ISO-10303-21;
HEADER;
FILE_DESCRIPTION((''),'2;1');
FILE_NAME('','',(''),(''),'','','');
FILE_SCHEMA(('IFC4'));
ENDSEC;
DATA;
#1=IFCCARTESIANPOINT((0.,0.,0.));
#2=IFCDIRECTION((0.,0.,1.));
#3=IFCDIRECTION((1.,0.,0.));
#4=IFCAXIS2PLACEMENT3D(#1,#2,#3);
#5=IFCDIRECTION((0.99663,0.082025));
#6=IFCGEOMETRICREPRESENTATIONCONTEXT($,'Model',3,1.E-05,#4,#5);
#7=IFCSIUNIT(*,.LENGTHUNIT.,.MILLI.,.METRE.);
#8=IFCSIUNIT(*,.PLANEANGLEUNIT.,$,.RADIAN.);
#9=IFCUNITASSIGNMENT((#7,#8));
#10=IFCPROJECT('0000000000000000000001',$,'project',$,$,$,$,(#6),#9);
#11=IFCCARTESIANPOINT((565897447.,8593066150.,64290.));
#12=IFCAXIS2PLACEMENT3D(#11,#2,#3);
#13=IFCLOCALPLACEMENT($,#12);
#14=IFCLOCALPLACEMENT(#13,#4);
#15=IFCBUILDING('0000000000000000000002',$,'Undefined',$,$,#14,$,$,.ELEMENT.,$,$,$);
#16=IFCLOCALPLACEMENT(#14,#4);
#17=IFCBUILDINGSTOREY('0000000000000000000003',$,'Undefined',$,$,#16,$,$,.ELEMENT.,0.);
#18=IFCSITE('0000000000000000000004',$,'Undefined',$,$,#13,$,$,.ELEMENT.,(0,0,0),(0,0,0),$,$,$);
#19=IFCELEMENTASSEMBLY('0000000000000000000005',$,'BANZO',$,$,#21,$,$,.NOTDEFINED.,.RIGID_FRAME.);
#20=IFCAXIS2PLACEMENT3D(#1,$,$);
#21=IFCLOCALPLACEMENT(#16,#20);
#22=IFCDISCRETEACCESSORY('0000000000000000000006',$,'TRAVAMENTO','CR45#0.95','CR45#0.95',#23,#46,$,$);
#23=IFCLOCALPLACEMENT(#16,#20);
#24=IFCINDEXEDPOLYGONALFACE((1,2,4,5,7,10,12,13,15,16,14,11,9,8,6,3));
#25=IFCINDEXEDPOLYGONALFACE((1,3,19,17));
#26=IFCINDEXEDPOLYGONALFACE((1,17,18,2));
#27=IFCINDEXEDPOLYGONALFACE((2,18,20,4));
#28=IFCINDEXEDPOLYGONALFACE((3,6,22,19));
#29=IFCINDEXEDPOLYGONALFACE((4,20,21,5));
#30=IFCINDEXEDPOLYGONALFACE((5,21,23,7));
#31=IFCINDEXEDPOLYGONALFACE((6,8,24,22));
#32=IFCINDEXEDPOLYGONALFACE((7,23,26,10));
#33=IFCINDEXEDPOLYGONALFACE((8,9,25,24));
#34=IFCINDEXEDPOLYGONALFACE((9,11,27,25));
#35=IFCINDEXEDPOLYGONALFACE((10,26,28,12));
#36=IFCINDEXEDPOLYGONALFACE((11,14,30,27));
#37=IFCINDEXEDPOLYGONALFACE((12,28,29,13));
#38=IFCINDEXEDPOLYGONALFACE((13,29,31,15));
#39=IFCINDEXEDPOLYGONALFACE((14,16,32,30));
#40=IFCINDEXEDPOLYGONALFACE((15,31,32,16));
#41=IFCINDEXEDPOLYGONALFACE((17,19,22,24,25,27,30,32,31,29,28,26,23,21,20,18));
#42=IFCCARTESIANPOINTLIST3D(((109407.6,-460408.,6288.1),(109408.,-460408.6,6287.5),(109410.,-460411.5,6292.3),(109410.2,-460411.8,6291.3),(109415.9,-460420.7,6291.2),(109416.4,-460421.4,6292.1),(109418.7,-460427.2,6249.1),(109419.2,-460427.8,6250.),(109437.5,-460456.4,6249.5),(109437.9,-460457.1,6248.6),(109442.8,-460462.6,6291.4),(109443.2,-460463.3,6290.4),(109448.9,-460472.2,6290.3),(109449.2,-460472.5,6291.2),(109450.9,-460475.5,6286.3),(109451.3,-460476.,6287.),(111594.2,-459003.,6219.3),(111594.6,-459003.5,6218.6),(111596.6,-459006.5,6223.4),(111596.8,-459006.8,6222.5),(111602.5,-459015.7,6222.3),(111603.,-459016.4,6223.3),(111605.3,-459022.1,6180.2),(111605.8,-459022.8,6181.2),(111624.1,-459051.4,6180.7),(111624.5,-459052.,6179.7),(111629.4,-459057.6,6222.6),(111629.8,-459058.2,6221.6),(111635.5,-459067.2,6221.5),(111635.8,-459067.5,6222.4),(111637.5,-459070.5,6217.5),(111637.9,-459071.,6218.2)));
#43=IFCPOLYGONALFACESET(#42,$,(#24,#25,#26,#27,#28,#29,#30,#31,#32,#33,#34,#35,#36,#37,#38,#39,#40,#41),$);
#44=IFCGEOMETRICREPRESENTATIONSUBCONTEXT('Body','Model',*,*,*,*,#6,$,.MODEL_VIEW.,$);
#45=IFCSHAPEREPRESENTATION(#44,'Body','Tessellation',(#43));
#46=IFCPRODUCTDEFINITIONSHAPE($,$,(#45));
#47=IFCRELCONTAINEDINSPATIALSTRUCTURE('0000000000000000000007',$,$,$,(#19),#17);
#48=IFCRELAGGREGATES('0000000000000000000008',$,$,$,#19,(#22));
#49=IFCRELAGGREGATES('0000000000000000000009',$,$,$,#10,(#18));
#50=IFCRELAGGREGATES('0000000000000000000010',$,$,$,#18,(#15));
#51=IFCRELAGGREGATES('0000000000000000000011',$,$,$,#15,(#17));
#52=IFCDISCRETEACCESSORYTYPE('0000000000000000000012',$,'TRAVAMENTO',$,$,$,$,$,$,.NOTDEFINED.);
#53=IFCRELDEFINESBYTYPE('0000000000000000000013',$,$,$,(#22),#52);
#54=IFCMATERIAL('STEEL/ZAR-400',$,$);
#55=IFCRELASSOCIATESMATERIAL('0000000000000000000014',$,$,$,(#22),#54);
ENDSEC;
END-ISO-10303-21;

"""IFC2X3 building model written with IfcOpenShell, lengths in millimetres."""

from ifc_helpers import new_model, si_unit, direction, frame, origin_with_axes, place, context, subcontext, project, spatial, polyline, outline, extrude, material, type_object, element, aggregate, save


model = new_model("IFC2X3")

# Units and contexts
model_context = context("Model", 3, precision=1e-05, world=origin_with_axes(), true_north=direction((0.99663, 0.082025)))
body_context = subcontext(model_context, "Body", "Model", "MODEL_VIEW")
ifc_project = project(units=[si_unit("LENGTHUNIT", "METRE", prefix="MILLI"), si_unit("PLANEANGLEUNIT", "RADIAN")], contexts=[model_context])

# Site, building, storey
site_placement = place(None, frame((565897447.0, 8593066150.0, 64290.0), z_axis=(0.0, 0.0, 1.0), x_axis=(1.0, 0.0, 0.0)))
site = spatial("IfcSite", under=ifc_project, at=site_placement, Name="Undefined", CompositionType="ELEMENT", RefLatitude=(0, 0, 0), RefLongitude=(0, 0, 0))
building_placement = place(site_placement, origin_with_axes())
building = spatial("IfcBuilding", under=site, at=building_placement, Name="Undefined", CompositionType="ELEMENT")
storey_placement = place(building_placement, origin_with_axes())
storey = spatial("IfcBuildingStorey", under=building, at=storey_placement, Name="Undefined", CompositionType="ELEMENT", Elevation=0.0)

# Shared definitions
ifc_material_1 = material(Name="STEEL/ZAR-400")

# Element assembly, discrete accessory
assembly_1_placement = place(storey_placement, origin_with_axes())
assembly_1 = element("IfcElementAssembly", 1, at=assembly_1_placement, inside=storey, Name="BANZO", AssemblyPlace="NOTDEFINED", PredefinedType="RIGID_FRAME")
discrete_accessory_type_1 = type_object("IfcDiscreteAccessoryType", Name="TRAVAMENTO")
discrete_accessory_1_placement = place(assembly_1_placement, frame((109429.1, -460442.3, 6270.3), z_axis=(-0.029884, -0.002459, -0.99955), x_axis=(0.840995, 0.540395, -0.026473)))
discrete_accessory_1 = element("IfcDiscreteAccessory", 2, at=discrete_accessory_1_placement, type_object=discrete_accessory_type_1, material=ifc_material_1, Name="TRAVAMENTO", Description="CR45#0.95", ObjectType="CR45#0.95", context=body_context, shape_type="SweptSolid", body=[
    extrude(outline(polyline([(-35.5, -20.5), (-24.9, -20.5), (-17.4, 21.5), (18.1, 21.5), (25.6, -20.5), (36.2, -20.5), (40.1, -16.6), (40.8, -17.3), (36.6, -21.5), (24.8, -21.5), (17.3, 20.5), (-16.6, 20.5), (-24.1, -21.5), (-35.9, -21.5), (-40.1, -17.3), (-39.4, -16.6), (-35.5, -20.5)])), frame((2600.0, 0.0, 0.0), z_axis=(-1.0, 0.0, 0.0), x_axis=(0.0, -1.0, 0.0)), (0.0, 0.0, 1.0), 2600.0),
])
aggregate(assembly_1, [discrete_accessory_1])

save(model, "model.ifc")
